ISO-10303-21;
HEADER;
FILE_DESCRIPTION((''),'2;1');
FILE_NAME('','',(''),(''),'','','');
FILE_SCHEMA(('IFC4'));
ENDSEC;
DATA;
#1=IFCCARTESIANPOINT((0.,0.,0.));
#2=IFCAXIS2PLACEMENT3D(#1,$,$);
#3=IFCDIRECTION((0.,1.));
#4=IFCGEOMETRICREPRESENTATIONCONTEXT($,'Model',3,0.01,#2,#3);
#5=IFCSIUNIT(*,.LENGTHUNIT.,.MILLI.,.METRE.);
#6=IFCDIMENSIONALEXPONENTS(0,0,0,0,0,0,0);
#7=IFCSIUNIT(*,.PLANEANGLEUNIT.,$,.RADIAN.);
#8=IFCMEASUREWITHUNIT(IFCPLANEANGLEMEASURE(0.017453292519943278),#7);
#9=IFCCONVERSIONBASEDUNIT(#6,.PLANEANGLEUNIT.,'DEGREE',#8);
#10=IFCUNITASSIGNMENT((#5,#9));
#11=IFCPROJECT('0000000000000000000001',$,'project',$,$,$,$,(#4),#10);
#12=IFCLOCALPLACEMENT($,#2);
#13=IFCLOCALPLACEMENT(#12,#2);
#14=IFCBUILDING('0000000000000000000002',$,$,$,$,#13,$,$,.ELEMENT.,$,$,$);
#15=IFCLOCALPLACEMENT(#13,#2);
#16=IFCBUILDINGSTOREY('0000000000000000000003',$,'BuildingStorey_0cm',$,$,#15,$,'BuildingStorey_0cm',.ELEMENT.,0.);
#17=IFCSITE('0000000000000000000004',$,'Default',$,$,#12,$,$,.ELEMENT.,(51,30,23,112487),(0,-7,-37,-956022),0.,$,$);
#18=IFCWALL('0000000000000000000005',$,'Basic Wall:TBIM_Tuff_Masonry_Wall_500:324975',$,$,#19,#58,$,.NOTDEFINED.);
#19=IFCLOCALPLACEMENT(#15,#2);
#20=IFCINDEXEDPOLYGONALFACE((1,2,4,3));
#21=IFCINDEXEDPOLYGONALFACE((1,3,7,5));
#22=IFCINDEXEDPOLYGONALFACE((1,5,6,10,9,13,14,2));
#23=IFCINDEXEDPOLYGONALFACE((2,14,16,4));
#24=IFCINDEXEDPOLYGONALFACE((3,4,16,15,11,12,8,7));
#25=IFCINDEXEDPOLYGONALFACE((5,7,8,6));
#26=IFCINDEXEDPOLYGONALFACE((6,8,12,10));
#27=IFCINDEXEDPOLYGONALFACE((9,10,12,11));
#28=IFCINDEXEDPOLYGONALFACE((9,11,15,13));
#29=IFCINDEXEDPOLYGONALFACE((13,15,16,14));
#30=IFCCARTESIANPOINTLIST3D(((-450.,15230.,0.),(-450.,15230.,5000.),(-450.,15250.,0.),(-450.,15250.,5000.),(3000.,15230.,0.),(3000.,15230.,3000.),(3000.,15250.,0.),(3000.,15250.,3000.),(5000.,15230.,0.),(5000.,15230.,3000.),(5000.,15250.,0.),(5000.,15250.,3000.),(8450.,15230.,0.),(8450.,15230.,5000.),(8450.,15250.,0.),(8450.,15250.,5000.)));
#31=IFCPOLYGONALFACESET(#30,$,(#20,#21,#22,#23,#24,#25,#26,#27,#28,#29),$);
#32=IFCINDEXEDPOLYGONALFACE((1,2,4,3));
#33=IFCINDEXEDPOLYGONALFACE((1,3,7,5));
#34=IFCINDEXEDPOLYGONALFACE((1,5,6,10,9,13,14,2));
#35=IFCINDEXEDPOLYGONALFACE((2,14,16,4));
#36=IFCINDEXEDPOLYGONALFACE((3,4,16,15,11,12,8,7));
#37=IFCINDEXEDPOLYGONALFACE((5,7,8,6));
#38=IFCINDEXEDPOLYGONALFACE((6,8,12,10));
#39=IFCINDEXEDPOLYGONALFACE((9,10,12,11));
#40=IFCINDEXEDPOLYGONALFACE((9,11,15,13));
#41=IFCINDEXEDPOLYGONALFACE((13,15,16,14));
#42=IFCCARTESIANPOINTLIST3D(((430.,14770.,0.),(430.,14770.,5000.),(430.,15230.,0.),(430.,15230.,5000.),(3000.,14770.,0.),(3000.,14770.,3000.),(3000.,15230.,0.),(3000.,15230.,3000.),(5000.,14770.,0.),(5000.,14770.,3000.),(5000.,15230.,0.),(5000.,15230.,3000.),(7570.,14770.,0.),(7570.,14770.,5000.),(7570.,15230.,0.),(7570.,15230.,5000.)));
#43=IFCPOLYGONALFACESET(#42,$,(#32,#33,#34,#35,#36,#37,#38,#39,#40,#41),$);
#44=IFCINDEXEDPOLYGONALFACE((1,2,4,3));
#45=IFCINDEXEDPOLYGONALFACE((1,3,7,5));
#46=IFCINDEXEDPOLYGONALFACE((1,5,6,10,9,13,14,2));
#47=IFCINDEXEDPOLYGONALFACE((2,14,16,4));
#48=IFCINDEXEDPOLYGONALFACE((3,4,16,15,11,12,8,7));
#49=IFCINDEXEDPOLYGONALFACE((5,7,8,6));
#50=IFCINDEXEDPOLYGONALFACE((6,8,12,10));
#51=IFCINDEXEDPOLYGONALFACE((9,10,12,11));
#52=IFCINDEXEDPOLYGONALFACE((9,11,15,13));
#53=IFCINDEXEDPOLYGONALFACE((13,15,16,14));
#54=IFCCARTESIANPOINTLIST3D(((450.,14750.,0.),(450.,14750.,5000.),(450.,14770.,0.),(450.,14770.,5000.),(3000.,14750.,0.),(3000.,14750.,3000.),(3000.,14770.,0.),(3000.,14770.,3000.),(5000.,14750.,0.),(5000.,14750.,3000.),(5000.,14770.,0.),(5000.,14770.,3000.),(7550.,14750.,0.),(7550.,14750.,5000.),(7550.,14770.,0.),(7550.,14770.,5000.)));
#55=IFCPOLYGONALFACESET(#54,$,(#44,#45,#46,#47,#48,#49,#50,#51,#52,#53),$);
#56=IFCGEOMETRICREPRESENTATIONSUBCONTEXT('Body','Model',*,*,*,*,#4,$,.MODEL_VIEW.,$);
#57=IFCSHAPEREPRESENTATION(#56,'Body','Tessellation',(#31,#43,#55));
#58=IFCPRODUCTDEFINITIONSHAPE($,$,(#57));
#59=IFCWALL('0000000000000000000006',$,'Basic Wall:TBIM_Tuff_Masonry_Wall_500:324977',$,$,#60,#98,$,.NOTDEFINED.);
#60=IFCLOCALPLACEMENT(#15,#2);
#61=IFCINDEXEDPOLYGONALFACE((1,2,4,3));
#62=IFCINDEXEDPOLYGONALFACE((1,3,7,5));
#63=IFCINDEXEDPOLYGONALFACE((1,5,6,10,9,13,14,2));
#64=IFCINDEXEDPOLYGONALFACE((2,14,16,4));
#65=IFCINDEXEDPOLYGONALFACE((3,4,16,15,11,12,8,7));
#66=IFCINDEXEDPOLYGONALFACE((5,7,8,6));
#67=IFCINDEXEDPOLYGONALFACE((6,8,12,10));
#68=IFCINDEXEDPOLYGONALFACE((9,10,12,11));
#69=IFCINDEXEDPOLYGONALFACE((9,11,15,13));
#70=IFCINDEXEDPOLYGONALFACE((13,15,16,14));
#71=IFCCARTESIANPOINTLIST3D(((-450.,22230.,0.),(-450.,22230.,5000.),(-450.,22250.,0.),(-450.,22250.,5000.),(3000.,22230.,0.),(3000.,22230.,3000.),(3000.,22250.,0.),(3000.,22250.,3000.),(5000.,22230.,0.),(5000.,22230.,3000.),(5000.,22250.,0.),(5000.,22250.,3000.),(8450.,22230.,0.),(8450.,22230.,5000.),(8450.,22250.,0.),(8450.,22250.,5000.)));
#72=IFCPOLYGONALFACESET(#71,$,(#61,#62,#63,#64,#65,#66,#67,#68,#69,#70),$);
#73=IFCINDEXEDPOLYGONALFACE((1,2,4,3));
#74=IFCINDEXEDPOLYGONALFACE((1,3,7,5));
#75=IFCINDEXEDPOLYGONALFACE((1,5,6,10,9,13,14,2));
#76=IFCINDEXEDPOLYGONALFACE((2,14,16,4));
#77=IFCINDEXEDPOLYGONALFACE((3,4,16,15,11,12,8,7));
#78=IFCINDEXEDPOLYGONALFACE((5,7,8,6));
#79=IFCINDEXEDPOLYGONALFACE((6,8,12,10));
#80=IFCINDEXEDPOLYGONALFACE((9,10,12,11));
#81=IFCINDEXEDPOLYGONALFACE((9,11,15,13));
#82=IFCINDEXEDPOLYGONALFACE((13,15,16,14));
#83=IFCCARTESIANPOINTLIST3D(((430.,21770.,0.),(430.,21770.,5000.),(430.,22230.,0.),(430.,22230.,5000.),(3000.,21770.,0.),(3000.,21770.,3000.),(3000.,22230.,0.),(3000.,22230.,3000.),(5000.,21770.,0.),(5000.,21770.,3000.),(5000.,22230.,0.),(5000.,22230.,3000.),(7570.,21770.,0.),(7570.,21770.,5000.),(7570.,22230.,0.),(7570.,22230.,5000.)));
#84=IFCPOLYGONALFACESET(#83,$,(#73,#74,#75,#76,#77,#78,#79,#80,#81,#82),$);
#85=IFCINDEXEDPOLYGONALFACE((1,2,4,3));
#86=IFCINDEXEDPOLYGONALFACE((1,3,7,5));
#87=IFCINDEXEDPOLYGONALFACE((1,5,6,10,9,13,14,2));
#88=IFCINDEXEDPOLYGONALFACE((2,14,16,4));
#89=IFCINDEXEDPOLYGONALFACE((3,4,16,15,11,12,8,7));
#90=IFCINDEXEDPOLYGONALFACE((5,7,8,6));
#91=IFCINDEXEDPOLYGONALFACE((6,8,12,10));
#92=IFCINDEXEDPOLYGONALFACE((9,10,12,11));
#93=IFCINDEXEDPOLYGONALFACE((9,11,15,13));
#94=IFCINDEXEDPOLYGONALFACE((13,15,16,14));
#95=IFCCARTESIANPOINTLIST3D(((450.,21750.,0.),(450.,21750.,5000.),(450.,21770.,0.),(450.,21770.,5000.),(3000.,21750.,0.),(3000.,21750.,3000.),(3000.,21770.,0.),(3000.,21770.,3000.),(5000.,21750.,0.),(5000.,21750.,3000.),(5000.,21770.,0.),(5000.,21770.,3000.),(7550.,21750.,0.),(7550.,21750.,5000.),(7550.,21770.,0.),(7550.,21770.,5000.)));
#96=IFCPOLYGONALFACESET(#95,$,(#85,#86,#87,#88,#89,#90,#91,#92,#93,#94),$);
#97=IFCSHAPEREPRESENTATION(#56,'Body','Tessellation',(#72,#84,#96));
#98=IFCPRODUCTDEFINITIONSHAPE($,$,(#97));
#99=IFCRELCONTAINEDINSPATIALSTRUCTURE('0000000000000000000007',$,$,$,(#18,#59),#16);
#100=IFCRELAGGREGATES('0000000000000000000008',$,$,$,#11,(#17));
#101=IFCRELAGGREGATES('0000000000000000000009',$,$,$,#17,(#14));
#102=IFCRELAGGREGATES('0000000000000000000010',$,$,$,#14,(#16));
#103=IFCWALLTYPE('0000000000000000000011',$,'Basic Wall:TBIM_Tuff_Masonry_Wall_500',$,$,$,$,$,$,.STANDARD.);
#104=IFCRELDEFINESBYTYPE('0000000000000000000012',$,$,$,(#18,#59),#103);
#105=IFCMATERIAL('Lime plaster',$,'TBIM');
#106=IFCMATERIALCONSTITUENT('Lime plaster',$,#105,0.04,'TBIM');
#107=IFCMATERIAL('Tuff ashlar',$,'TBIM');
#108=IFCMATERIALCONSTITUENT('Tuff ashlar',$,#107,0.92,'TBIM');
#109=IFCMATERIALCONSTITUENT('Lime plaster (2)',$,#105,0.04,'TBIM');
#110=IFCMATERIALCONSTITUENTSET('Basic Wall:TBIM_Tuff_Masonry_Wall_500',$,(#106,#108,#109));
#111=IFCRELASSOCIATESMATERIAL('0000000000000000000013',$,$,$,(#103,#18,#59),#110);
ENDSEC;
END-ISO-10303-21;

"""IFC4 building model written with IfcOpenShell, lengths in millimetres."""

from ifc_helpers import new_model, entity, si_unit, converted_unit, direction, frame, origin, place, context, subcontext, project, spatial, indexed_curve, outline, extrude, material, constituent, constituent_set, type_object, element, save


model = new_model("IFC4")

# Units and contexts
model_context = context("Model", 3, precision=0.01, world=origin(), true_north=direction((0.0, 1.0)))
body_context = subcontext(model_context, "Body", "Model", "MODEL_VIEW")
ifc_project = project(units=[si_unit("LENGTHUNIT", "METRE", prefix="MILLI"), converted_unit("PLANEANGLEUNIT", "DEGREE", entity("IfcPlaneAngleMeasure", 0.017453292519943278), si_unit("PLANEANGLEUNIT", "RADIAN"), dimensions=[0, 0, 0, 0, 0, 0, 0])], contexts=[model_context])

# Site, building, storey
site_placement = place(None, origin())
site = spatial("IfcSite", under=ifc_project, at=site_placement, Name="Default", CompositionType="ELEMENT", RefLatitude=(51, 30, 23, 112487), RefLongitude=(0, -7, -37, -956022), RefElevation=0.0)
building_placement = place(site_placement, origin())
building = spatial("IfcBuilding", under=site, at=building_placement, CompositionType="ELEMENT")
storey_placement = place(building_placement, origin())
storey = spatial("IfcBuildingStorey", under=building, at=storey_placement, Name="BuildingStorey_0cm", LongName="BuildingStorey_0cm", CompositionType="ELEMENT", Elevation=0.0)

# Shared definitions
ifc_material_1 = material(Name="Tuff ashlar", Category="TBIM")
ifc_material_2 = material(Name="Lime plaster", Category="TBIM")

# Walls, openings
ifc_constituent_1 = constituent(ifc_material_2, Name="Lime plaster", Category="TBIM", fraction=0.04)
ifc_constituent_2 = constituent(ifc_material_1, Name="Tuff ashlar", Category="TBIM", fraction=0.92)
ifc_constituent_3 = constituent(ifc_material_2, Name="Lime plaster (2)", Category="TBIM", fraction=0.04)
ifc_constituent_set_1 = constituent_set(constituents=[ifc_constituent_1, ifc_constituent_2, ifc_constituent_3], Name="Basic Wall:TBIM_Tuff_Masonry_Wall_500")
wall_type_1 = type_object("IfcWallType", Name="Basic Wall:TBIM_Tuff_Masonry_Wall_500", PredefinedType="STANDARD", material=ifc_constituent_set_1)
wall_1_placement = place(storey_placement, frame((450.0, 15000.0, 0.0)))
wall_1 = element("IfcWall", 1, at=wall_1_placement, inside=storey, type_object=wall_type_1, material=ifc_constituent_set_1, Name="Basic Wall:TBIM_Tuff_Masonry_Wall_500:324975", PredefinedType="NOTDEFINED", context=body_context, shape_type="SweptSolid", body=[
    extrude(outline(indexed_curve([(-2000.0, -4450.0), (3000.0, -4450.0), (3000.0, 4450.0), (-2000.0, 4450.0), (-2000.0, 1000.0), (1000.0, 1000.0), (1000.0, -1000.0), (-2000.0, -1000.0), (-2000.0, -4450.0)], self_intersect=False)), frame((3550.0, 230.0, 2000.0), z_axis=(0.0, 1.0, 0.0), x_axis=(0.0, 0.0, 1.0)), (0.0, 0.0, 1.0), 20.0),
    extrude(outline(indexed_curve([(-2000.0, -3570.0), (3000.0, -3570.0), (3000.0, 3570.0), (-2000.0, 3570.0), (-2000.0, 1000.0), (1000.0, 1000.0), (1000.0, -1000.0), (-2000.0, -1000.0), (-2000.0, -3570.0)], self_intersect=False)), frame((3550.0, -230.0, 2000.0), z_axis=(0.0, 1.0, 0.0), x_axis=(0.0, 0.0, 1.0)), (0.0, 0.0, 1.0), 460.0),
    extrude(outline(indexed_curve([(-1000.0, -1000.0), (-1000.0, 2000.0), (-3550.0, 2000.0), (-3550.0, -3000.0), (3550.0, -3000.0), (3550.0, 2000.0), (1000.0, 2000.0), (1000.0, -1000.0), (-1000.0, -1000.0)], self_intersect=False)), frame((3550.0, -250.0, 2000.0), z_axis=(0.0, -1.0, 0.0), x_axis=(-1.0, 0.0, 0.0)), (0.0, 0.0, -1.0), 20.0),
])
opening_1_placement = place(wall_1_placement, frame((4550.0, 250.0, 0.0)))
element("IfcOpeningElement", 2, at=opening_1_placement, cuts=wall_1, PredefinedType="OPENING", context=body_context, shape_type="SweptSolid", body=[
    extrude(outline(indexed_curve([(3000.0, 2000.0), (0.0, 2000.0), (0.0, 0.0), (3000.0, 0.0), (3000.0, 2000.0)], self_intersect=False)), frame((0.0, 0.0, 0.0), z_axis=(0.0, -1.0, 0.0), x_axis=(0.0, 0.0, 1.0)), (0.0, 0.0, 1.0), 500.0),
])
wall_2_placement = place(storey_placement, frame((450.0, 22000.0, 0.0)))
wall_2 = element("IfcWall", 3, at=wall_2_placement, inside=storey, type_object=wall_type_1, material=ifc_constituent_set_1, Name="Basic Wall:TBIM_Tuff_Masonry_Wall_500:324977", PredefinedType="NOTDEFINED", context=body_context, shape_type="SweptSolid", body=[
    extrude(outline(indexed_curve([(-2000.0, -4450.0), (3000.0, -4450.0), (3000.0, 4450.0), (-2000.0, 4450.0), (-2000.0, 1000.0), (1000.0, 1000.0), (1000.0, -1000.0), (-2000.0, -1000.0), (-2000.0, -4450.0)], self_intersect=False)), frame((3550.0, 230.0, 2000.0), z_axis=(0.0, 1.0, 0.0), x_axis=(0.0, 0.0, 1.0)), (0.0, 0.0, 1.0), 20.0),
    extrude(outline(indexed_curve([(-2000.0, -3570.0), (3000.0, -3570.0), (3000.0, 3570.0), (-2000.0, 3570.0), (-2000.0, 1000.0), (1000.0, 1000.0), (1000.0, -1000.0), (-2000.0, -1000.0), (-2000.0, -3570.0)], self_intersect=False)), frame((3550.0, -230.0, 2000.0), z_axis=(0.0, 1.0, 0.0), x_axis=(0.0, 0.0, 1.0)), (0.0, 0.0, 1.0), 460.0),
    extrude(outline(indexed_curve([(-1000.0, -1000.0), (-1000.0, 2000.0), (-3550.0, 2000.0), (-3550.0, -3000.0), (3550.0, -3000.0), (3550.0, 2000.0), (1000.0, 2000.0), (1000.0, -1000.0), (-1000.0, -1000.0)], self_intersect=False)), frame((3550.0, -250.0, 2000.0), z_axis=(0.0, -1.0, 0.0), x_axis=(-1.0, 0.0, 0.0)), (0.0, 0.0, -1.0), 20.0),
])
opening_2_placement = place(wall_2_placement, frame((4550.0, 250.0, 0.0)))
element("IfcOpeningElement", 4, at=opening_2_placement, cuts=wall_2, PredefinedType="OPENING", context=body_context, shape_type="SweptSolid", body=[
    extrude(outline(indexed_curve([(3000.0, 2000.0), (0.0, 2000.0), (0.0, 0.0), (3000.0, 0.0), (3000.0, 2000.0)], self_intersect=False)), frame((0.0, 0.0, 0.0), z_axis=(0.0, -1.0, 0.0), x_axis=(0.0, 0.0, 1.0)), (0.0, 0.0, 1.0), 500.0),
])

save(model, "model.ifc")
